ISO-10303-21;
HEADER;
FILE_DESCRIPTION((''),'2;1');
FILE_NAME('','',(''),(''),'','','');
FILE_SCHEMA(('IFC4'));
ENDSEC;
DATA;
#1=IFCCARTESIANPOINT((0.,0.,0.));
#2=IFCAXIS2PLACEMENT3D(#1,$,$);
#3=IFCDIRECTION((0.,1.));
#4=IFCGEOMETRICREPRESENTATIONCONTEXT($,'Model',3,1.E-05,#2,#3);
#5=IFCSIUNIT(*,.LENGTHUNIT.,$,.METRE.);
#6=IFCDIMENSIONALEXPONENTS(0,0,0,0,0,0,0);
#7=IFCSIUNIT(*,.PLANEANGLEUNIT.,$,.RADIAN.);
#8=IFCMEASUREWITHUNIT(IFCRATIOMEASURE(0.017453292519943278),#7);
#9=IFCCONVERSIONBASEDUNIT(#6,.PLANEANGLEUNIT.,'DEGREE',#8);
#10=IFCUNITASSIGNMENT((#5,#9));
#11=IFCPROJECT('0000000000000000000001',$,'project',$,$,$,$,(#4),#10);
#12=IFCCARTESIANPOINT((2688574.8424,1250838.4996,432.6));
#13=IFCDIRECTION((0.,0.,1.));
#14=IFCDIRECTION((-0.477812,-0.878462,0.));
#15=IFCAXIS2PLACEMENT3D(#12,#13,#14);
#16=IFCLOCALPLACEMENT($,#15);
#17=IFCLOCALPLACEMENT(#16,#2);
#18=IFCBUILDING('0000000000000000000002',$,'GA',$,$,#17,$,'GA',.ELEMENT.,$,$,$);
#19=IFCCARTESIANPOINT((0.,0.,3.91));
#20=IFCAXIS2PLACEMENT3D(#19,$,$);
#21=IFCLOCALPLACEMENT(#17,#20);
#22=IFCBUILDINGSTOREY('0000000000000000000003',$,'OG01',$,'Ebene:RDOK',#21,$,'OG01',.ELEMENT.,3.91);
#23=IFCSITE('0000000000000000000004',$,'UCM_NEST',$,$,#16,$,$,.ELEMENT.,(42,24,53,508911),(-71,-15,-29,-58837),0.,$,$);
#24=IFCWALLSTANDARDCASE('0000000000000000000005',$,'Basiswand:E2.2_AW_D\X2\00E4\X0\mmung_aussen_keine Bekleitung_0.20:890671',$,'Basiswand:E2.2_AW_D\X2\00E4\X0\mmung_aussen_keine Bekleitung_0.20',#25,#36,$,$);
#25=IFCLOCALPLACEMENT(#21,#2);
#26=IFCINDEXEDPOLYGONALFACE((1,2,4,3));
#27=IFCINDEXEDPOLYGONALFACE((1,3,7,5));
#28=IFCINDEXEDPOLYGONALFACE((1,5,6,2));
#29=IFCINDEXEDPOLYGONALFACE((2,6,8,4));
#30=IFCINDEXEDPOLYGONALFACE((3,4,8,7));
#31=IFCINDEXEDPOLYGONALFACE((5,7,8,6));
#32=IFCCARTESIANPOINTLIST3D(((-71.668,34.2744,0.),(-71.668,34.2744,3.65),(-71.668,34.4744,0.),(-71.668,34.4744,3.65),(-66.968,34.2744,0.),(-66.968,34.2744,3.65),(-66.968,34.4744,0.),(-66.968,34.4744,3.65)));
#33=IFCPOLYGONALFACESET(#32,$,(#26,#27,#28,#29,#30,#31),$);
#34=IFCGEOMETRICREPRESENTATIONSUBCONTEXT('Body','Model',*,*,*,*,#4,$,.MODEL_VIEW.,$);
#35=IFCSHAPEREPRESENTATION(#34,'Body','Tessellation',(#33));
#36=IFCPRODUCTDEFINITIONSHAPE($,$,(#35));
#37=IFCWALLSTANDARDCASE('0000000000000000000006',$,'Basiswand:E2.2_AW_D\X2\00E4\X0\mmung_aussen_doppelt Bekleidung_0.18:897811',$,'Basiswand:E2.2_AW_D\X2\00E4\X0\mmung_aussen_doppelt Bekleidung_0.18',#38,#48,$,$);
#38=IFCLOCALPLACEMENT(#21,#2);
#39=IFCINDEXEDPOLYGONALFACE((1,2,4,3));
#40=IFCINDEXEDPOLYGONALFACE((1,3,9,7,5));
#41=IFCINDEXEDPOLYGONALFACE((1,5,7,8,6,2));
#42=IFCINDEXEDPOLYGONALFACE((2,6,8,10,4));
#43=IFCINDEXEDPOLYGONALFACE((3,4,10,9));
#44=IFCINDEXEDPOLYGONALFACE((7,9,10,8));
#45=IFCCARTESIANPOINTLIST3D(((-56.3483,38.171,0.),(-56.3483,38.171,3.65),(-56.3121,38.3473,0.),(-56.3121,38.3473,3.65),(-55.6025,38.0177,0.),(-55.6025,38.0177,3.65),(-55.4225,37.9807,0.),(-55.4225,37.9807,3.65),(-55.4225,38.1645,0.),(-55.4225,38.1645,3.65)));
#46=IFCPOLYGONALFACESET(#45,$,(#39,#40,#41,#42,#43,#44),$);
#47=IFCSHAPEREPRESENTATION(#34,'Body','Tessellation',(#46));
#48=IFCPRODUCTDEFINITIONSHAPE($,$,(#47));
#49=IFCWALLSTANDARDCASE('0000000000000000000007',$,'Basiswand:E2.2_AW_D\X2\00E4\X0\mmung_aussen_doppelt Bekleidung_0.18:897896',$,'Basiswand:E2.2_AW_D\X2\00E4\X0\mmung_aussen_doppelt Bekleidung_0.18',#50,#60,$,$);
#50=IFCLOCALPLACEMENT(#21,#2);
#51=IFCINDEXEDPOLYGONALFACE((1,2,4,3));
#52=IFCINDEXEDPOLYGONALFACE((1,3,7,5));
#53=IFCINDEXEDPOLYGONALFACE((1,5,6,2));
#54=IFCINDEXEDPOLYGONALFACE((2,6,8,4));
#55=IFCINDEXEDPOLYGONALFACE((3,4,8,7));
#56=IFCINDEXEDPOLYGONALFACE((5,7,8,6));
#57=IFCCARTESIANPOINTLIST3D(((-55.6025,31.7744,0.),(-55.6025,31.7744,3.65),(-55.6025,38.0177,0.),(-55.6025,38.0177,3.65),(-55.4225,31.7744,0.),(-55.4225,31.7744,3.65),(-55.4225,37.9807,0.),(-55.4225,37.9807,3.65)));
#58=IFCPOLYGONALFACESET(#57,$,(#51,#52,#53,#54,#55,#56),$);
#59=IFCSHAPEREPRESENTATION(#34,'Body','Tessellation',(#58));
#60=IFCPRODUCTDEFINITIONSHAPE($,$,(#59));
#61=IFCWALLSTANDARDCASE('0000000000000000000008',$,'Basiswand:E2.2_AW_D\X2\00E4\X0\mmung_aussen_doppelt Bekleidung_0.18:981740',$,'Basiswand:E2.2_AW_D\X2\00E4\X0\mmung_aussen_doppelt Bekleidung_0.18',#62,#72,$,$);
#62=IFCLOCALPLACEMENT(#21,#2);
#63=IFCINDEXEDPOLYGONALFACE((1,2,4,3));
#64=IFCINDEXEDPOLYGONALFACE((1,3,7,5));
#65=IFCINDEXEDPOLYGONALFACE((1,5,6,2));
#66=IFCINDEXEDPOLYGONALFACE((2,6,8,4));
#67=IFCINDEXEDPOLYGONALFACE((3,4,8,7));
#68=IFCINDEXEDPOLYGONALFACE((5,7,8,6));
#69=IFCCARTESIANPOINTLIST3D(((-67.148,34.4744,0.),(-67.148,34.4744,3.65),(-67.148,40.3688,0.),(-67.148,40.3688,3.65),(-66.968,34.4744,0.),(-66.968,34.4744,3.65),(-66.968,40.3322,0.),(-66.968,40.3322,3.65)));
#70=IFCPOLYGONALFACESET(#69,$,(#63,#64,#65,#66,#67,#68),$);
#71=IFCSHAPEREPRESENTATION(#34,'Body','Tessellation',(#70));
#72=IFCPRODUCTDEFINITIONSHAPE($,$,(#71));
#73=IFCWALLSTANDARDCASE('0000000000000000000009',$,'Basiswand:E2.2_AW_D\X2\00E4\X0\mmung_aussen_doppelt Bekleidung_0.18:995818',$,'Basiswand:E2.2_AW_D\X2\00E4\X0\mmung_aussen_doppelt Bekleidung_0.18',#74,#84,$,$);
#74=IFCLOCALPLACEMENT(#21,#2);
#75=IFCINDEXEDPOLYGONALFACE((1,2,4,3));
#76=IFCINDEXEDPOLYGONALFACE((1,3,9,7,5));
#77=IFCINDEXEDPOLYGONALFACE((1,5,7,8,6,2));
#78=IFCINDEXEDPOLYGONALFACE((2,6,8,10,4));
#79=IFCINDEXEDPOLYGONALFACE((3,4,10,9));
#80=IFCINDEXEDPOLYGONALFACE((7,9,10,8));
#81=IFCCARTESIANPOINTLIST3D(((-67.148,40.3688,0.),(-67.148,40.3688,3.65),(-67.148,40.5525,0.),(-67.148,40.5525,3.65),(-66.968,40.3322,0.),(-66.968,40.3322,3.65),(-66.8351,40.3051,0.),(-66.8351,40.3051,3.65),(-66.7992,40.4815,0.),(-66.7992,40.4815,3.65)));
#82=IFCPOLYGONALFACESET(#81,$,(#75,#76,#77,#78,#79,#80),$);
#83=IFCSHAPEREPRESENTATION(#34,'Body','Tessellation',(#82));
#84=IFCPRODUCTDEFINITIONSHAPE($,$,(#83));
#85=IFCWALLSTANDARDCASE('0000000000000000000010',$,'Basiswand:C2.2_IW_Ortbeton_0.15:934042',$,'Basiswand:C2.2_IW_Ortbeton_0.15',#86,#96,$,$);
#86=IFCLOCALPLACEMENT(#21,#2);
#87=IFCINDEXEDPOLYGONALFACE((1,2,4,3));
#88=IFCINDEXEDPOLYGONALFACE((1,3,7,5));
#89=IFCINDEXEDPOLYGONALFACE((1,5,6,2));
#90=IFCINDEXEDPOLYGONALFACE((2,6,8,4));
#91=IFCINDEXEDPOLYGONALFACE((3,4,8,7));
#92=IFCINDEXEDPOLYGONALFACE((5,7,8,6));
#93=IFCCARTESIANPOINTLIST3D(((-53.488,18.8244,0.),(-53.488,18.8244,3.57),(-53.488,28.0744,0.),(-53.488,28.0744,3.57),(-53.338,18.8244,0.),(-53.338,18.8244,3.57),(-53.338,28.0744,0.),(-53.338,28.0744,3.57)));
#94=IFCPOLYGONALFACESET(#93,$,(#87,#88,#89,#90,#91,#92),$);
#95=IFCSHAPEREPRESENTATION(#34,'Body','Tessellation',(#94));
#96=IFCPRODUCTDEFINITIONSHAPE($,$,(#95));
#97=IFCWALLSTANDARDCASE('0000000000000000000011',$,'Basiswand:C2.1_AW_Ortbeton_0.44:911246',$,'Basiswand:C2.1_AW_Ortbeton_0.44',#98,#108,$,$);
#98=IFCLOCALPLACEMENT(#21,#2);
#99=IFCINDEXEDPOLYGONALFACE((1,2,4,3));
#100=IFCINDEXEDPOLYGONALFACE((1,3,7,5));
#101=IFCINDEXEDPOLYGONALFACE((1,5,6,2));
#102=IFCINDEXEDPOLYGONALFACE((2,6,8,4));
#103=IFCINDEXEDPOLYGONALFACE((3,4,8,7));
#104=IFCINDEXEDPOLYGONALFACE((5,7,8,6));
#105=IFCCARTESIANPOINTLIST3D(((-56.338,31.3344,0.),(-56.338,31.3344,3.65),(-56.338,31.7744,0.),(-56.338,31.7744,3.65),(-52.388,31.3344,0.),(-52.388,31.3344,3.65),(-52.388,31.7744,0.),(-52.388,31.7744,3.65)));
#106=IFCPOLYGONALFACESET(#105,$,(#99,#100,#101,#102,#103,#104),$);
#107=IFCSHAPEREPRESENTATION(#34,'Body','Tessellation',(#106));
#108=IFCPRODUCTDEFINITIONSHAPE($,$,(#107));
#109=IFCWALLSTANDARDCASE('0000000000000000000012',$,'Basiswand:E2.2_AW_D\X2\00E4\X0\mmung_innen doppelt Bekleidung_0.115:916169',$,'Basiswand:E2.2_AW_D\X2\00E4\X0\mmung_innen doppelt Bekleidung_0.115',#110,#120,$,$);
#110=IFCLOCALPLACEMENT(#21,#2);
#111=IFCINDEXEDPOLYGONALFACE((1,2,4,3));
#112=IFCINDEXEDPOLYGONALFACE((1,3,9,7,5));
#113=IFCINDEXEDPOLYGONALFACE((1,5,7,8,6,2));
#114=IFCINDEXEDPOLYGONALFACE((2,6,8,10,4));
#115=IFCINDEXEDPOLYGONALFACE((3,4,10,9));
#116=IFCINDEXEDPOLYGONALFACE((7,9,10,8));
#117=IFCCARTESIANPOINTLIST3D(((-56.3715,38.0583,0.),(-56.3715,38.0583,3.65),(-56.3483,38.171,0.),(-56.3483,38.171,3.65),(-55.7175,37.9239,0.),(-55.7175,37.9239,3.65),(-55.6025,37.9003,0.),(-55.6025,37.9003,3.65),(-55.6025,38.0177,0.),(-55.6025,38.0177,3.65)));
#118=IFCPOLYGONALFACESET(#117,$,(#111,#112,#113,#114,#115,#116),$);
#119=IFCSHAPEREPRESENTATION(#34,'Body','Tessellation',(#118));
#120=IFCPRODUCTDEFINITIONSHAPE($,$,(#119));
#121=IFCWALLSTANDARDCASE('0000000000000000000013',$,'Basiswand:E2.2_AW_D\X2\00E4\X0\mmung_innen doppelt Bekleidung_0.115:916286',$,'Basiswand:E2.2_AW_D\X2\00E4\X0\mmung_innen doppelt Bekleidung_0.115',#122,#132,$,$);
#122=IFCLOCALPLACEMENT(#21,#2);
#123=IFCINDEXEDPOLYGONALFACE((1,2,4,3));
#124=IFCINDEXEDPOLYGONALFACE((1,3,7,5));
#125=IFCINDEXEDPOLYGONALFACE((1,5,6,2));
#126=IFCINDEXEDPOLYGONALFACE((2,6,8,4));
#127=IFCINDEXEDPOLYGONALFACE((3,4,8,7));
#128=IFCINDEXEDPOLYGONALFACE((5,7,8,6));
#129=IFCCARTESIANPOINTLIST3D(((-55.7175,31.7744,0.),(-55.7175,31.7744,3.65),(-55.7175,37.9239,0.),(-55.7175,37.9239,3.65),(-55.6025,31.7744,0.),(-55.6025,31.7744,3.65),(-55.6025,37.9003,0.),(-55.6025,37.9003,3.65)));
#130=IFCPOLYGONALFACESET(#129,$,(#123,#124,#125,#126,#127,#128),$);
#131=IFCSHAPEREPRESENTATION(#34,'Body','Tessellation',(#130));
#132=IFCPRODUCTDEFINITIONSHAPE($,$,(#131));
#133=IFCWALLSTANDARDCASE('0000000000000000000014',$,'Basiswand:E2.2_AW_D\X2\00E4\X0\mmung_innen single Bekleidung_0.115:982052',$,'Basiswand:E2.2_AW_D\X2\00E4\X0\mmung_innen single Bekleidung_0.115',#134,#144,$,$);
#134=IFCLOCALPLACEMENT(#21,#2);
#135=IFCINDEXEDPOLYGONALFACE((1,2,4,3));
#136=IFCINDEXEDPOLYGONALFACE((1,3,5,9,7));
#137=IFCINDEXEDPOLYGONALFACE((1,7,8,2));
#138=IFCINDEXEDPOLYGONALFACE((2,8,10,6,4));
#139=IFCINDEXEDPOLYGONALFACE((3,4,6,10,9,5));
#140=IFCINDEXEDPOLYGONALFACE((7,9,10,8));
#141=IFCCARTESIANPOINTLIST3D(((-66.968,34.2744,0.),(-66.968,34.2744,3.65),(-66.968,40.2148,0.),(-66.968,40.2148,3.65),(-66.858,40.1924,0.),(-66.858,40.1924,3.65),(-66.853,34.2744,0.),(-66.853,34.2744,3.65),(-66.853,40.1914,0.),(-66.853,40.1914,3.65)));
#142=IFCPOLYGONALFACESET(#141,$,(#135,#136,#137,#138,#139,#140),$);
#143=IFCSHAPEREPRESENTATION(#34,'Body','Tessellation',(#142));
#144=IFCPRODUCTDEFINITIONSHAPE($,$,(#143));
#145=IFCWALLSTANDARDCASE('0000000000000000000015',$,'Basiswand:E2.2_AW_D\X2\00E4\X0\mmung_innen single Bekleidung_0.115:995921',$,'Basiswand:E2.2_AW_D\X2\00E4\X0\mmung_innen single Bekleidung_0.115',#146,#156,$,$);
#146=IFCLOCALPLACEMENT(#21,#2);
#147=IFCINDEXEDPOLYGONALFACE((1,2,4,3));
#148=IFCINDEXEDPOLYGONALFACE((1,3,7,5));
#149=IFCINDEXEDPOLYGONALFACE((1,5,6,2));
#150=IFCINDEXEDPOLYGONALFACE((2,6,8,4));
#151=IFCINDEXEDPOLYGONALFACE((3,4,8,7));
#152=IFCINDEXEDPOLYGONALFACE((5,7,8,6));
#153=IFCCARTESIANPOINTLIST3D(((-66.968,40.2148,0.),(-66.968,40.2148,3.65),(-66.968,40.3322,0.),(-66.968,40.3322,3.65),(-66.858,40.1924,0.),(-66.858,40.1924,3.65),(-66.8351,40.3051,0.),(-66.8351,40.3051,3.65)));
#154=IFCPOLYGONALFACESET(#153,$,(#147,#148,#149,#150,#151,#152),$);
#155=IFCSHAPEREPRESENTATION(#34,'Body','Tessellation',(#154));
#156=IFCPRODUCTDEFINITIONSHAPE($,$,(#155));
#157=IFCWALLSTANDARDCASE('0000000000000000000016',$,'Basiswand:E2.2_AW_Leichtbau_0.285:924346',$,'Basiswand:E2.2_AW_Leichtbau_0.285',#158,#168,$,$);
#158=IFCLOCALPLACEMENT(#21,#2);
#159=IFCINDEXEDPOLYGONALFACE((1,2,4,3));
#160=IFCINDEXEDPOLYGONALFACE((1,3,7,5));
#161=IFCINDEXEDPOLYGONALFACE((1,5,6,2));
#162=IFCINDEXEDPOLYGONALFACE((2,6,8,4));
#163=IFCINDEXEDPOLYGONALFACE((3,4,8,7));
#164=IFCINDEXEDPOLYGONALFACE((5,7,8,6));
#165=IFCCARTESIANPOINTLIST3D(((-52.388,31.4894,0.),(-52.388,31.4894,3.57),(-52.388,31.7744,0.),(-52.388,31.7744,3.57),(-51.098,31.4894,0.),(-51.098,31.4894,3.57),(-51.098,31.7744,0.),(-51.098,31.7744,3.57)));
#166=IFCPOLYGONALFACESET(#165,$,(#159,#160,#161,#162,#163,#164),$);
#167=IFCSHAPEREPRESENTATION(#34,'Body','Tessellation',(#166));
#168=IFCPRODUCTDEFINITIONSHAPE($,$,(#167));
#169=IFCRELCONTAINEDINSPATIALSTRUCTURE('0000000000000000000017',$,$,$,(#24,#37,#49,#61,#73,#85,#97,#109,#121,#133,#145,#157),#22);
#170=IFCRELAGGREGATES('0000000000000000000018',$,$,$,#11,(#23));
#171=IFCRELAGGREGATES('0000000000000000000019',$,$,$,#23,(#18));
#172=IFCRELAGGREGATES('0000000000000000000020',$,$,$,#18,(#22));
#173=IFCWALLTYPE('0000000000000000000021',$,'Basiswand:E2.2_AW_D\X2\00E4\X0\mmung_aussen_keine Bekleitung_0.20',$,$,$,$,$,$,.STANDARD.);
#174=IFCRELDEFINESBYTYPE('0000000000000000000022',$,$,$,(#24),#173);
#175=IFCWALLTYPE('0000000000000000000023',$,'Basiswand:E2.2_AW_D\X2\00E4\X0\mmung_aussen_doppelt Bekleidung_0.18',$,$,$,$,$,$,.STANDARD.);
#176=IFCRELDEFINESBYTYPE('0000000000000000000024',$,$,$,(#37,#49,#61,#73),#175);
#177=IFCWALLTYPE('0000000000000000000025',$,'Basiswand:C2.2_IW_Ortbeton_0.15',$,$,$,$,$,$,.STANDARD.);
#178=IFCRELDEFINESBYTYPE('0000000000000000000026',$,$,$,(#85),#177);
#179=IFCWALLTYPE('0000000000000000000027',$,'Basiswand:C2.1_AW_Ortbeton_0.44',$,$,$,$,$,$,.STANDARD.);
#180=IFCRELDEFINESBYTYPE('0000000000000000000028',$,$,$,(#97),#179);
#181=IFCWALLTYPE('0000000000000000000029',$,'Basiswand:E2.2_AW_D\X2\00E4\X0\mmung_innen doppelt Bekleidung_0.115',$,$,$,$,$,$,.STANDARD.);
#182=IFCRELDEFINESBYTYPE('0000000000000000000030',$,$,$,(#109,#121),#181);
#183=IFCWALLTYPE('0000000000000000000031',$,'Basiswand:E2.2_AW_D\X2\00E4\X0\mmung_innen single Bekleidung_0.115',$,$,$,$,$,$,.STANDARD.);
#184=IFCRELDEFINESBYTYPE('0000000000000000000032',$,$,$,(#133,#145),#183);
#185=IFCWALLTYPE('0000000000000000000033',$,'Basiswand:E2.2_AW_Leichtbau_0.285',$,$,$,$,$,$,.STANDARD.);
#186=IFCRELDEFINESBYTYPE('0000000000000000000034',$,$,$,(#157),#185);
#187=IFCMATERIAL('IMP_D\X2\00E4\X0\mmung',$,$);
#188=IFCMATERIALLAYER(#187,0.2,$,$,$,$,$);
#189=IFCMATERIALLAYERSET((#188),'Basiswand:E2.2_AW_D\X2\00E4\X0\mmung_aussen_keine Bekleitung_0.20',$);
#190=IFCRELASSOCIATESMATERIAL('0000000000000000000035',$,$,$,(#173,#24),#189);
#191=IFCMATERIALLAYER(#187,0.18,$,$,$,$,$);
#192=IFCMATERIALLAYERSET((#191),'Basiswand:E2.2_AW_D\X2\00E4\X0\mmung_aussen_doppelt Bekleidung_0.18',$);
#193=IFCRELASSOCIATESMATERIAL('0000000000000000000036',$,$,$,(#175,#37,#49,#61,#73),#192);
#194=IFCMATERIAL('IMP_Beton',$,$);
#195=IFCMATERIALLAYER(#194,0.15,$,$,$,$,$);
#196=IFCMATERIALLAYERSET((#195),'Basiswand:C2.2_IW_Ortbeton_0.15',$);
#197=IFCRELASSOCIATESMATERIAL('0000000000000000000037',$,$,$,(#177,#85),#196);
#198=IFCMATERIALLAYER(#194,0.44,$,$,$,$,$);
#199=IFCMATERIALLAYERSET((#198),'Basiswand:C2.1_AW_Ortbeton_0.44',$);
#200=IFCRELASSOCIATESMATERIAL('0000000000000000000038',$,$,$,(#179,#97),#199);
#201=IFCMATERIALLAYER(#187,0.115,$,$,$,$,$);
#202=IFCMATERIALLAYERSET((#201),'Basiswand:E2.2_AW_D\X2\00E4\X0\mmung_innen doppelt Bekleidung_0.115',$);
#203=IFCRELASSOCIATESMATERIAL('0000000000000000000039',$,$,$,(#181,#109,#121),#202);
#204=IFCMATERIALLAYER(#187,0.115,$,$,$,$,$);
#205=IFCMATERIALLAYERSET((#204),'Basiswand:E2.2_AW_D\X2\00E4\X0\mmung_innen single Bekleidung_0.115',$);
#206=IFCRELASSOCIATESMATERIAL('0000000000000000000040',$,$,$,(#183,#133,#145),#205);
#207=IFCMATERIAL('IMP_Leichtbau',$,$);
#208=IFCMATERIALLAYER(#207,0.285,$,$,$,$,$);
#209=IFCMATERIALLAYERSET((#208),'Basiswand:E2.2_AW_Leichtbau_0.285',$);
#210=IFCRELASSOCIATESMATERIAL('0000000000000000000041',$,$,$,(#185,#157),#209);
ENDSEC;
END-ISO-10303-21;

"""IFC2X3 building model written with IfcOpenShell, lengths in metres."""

from ifc_helpers import new_model, entity, si_unit, converted_unit, direction, frame, frame_2d, origin, place, context, subcontext, project, spatial, polyline, rectangle, outline, extrude, clip, bounded_halfspace, material, layer, layer_set, layer_usage, type_object, element, save


model = new_model("IFC2X3")

# Units and contexts
model_context = context("Model", 3, precision=1e-05, world=origin(), true_north=direction((0.0, 1.0)))
body_context = subcontext(model_context, "Body", "Model", "MODEL_VIEW")
ifc_project = project(units=[si_unit("LENGTHUNIT", "METRE"), converted_unit("PLANEANGLEUNIT", "DEGREE", entity("IfcRatioMeasure", 0.017453292519943278), si_unit("PLANEANGLEUNIT", "RADIAN"), dimensions=[0, 0, 0, 0, 0, 0, 0])], contexts=[model_context])

# Site, building, storey
site_placement = place(None, frame((2688574.8424, 1250838.4996, 432.6), z_axis=(0.0, 0.0, 1.0), x_axis=(-0.477812, -0.878462, 0.0)))
site = spatial("IfcSite", under=ifc_project, at=site_placement, Name="UCM_NEST", CompositionType="ELEMENT", RefLatitude=(42, 24, 53, 508911), RefLongitude=(-71, -15, -29, -58837), RefElevation=0.0)
building_placement = place(site_placement, origin())
building = spatial("IfcBuilding", under=site, at=building_placement, Name="GA", LongName="GA", CompositionType="ELEMENT")
storey_placement = place(building_placement, frame((0.0, 0.0, 3.91)))
storey = spatial("IfcBuildingStorey", under=building, at=storey_placement, Name="OG01", ObjectType="Ebene:RDOK", LongName="OG01", CompositionType="ELEMENT", Elevation=3.91)

# Walls
ifc_material_1 = material(Name="IMP_Dämmung")
ifc_layer_1 = layer(ifc_material_1, 0.2)
ifc_layer_set_1 = layer_set([ifc_layer_1], Name="Basiswand:E2.2_AW_Dämmung_aussen_keine Bekleitung_0.20")
ifc_layer_usage_1 = layer_usage(ifc_layer_set_1, "AXIS2", "NEGATIVE", 0.1)
wall_type_1 = type_object("IfcWallType", Name="Basiswand:E2.2_AW_Dämmung_aussen_keine Bekleitung_0.20", PredefinedType="STANDARD", material=ifc_layer_set_1)
wall_1_placement = place(storey_placement, frame((-66.968, 34.3744, 0.0), z_axis=(0.0, 0.0, 1.0), x_axis=(-1.0, 0.0, 0.0)))
element("IfcWallStandardCase", 1, at=wall_1_placement, inside=storey, type_object=wall_type_1, material=ifc_layer_usage_1, Name="Basiswand:E2.2_AW_Dämmung_aussen_keine Bekleitung_0.20:890671", ObjectType="Basiswand:E2.2_AW_Dämmung_aussen_keine Bekleitung_0.20", context=body_context, shape_type="SweptSolid", body=[
    extrude(rectangle(XDim=4.7, YDim=0.2, at=frame_2d((2.35, 0.0), x_axis=(-1.0, 0.0))), origin(), (0.0, 0.0, 1.0), 3.65),
])
ifc_layer_2 = layer(ifc_material_1, 0.18)
ifc_layer_set_2 = layer_set([ifc_layer_2], Name="Basiswand:E2.2_AW_Dämmung_aussen_doppelt Bekleidung_0.18")
ifc_layer_usage_2 = layer_usage(ifc_layer_set_2, "AXIS2", "NEGATIVE", 0.09)
wall_type_2 = type_object("IfcWallType", Name="Basiswand:E2.2_AW_Dämmung_aussen_doppelt Bekleidung_0.18", PredefinedType="STANDARD", material=ifc_layer_set_2)
wall_2_placement = place(storey_placement, frame((-56.3302, 38.2591, 0.0), z_axis=(0.0, 0.0, 1.0), x_axis=(0.979529, -0.201305, 0.0)))
element("IfcWallStandardCase", 2, at=wall_2_placement, inside=storey, type_object=wall_type_2, material=ifc_layer_usage_2, Name="Basiswand:E2.2_AW_Dämmung_aussen_doppelt Bekleidung_0.18:897811", ObjectType="Basiswand:E2.2_AW_Dämmung_aussen_doppelt Bekleidung_0.18", context=body_context, shape_type="SweptSolid", body=[
    extrude(outline(polyline([(0.9451, -0.09), (0.9081, 0.09), (0.0, 0.09), (0.0, -0.09), (0.7614, -0.09), (0.9451, -0.09)])), origin(), (0.0, 0.0, 1.0), 3.65),
])
wall_3_placement = place(storey_placement, frame((-55.5125, 38.0177, 0.0), z_axis=(0.0, 0.0, 1.0), x_axis=(0.0, -1.0, 0.0)))
element("IfcWallStandardCase", 3, at=wall_3_placement, inside=storey, type_object=wall_type_2, material=ifc_layer_usage_2, Name="Basiswand:E2.2_AW_Dämmung_aussen_doppelt Bekleidung_0.18:897896", ObjectType="Basiswand:E2.2_AW_Dämmung_aussen_doppelt Bekleidung_0.18", context=body_context, shape_type="SweptSolid", body=[
    extrude(outline(polyline([(6.2433, -0.09), (6.2433, 0.09), (0.037, 0.09), (0.0, -0.09), (6.2433, -0.09)])), origin(), (0.0, 0.0, 1.0), 3.65),
])
wall_4_placement = place(storey_placement, frame((-67.058, 34.4744, 0.0), z_axis=(0.0, 0.0, 1.0), x_axis=(0.0, 1.0, 0.0)))
element("IfcWallStandardCase", 4, at=wall_4_placement, inside=storey, type_object=wall_type_2, material=ifc_layer_usage_2, Name="Basiswand:E2.2_AW_Dämmung_aussen_doppelt Bekleidung_0.18:981740", ObjectType="Basiswand:E2.2_AW_Dämmung_aussen_doppelt Bekleidung_0.18", context=body_context, shape_type="SweptSolid", body=[
    extrude(outline(polyline([(5.8577, -0.09), (5.8943, 0.09), (0.0, 0.09), (0.0, -0.09), (5.8577, -0.09)])), origin(), (0.0, 0.0, 1.0), 3.65),
])
wall_5_placement = place(storey_placement, frame((-67.1659, 40.4643, 0.0), z_axis=(0.0, 0.0, 1.0), x_axis=(0.979914, -0.199421, 0.0)))
element("IfcWallStandardCase", 5, at=wall_5_placement, inside=storey, type_object=wall_type_2, material=ifc_layer_usage_2, Name="Basiswand:E2.2_AW_Dämmung_aussen_doppelt Bekleidung_0.18:995818", ObjectType="Basiswand:E2.2_AW_Dämmung_aussen_doppelt Bekleidung_0.18", context=body_context, shape_type="SweptSolid", body=[
    extrude(outline(polyline([(0.356, -0.09), (0.356, 0.09), (0.0, 0.09), (0.0366, -0.09), (0.2203, -0.09), (0.356, -0.09)])), origin(), (0.0, 0.0, 1.0), 3.65),
])
ifc_material_2 = material(Name="IMP_Beton")
ifc_layer_3 = layer(ifc_material_2, 0.15)
ifc_layer_set_3 = layer_set([ifc_layer_3], Name="Basiswand:C2.2_IW_Ortbeton_0.15")
ifc_layer_usage_3 = layer_usage(ifc_layer_set_3, "AXIS2", "NEGATIVE", 0.075)
wall_type_3 = type_object("IfcWallType", Name="Basiswand:C2.2_IW_Ortbeton_0.15", PredefinedType="STANDARD", material=ifc_layer_set_3)
wall_6_placement = place(storey_placement, frame((-53.413, 28.0744, 0.0), z_axis=(0.0, 0.0, 1.0), x_axis=(0.0, -1.0, 0.0)))
element("IfcWallStandardCase", 6, at=wall_6_placement, inside=storey, type_object=wall_type_3, material=ifc_layer_usage_3, Name="Basiswand:C2.2_IW_Ortbeton_0.15:934042", ObjectType="Basiswand:C2.2_IW_Ortbeton_0.15", context=body_context, shape_type="Clipping", body=[
    clip(extrude(rectangle(XDim=9.25, YDim=0.15, at=frame_2d((4.625, 0.0), x_axis=(-1.0, 0.0))), origin(), (0.0, 0.0, 1.0), 3.57), bounded_halfspace(frame((0.0, -0.075, 3.57), z_axis=(0.0, 0.0, -1.0), x_axis=(1.0, 0.0, 0.0)), True, frame((0.0, -0.075, 3.57), z_axis=(0.0, 0.0, -1.0), x_axis=(1.0, 0.0, 0.0)), polyline([(0.0, 0.0), (0.0, -0.15), (9.1, -0.15), (9.25, -0.15), (9.25, 0.0), (0.0, 0.0)]))),
])
ifc_layer_4 = layer(ifc_material_2, 0.44)
ifc_layer_set_4 = layer_set([ifc_layer_4], Name="Basiswand:C2.1_AW_Ortbeton_0.44")
ifc_layer_usage_4 = layer_usage(ifc_layer_set_4, "AXIS2", "NEGATIVE", 0.22)
wall_type_4 = type_object("IfcWallType", Name="Basiswand:C2.1_AW_Ortbeton_0.44", PredefinedType="STANDARD", material=ifc_layer_set_4)
wall_7_placement = place(storey_placement, frame((-56.338, 31.5544, 0.0)))
element("IfcWallStandardCase", 7, at=wall_7_placement, inside=storey, type_object=wall_type_4, material=ifc_layer_usage_4, Name="Basiswand:C2.1_AW_Ortbeton_0.44:911246", ObjectType="Basiswand:C2.1_AW_Ortbeton_0.44", context=body_context, shape_type="SweptSolid", body=[
    extrude(rectangle(XDim=3.95, YDim=0.44, at=frame_2d((1.975, 0.0), x_axis=(-1.0, 0.0))), origin(), (0.0, 0.0, 1.0), 3.65),
])

# Walls
ifc_layer_5 = layer(ifc_material_1, 0.115)
ifc_layer_set_5 = layer_set([ifc_layer_5], Name="Basiswand:E2.2_AW_Dämmung_innen doppelt Bekleidung_0.115")
ifc_layer_usage_5 = layer_usage(ifc_layer_set_5, "AXIS2", "NEGATIVE", 0.0575)
wall_type_5 = type_object("IfcWallType", Name="Basiswand:E2.2_AW_Dämmung_innen doppelt Bekleidung_0.115", PredefinedType="STANDARD", material=ifc_layer_set_5)
wall_8_placement = place(storey_placement, frame((-56.3599, 38.1146, 0.0), z_axis=(0.0, 0.0, 1.0), x_axis=(0.979529, -0.201305, 0.0)))
element("IfcWallStandardCase", 8, at=wall_8_placement, inside=storey, type_object=wall_type_5, material=ifc_layer_usage_5, Name="Basiswand:E2.2_AW_Dämmung_innen doppelt Bekleidung_0.115:916169", ObjectType="Basiswand:E2.2_AW_Dämmung_innen doppelt Bekleidung_0.115", context=body_context, shape_type="SweptSolid", body=[
    extrude(outline(polyline([(0.785, -0.0575), (0.7614, 0.0575), (0.0, 0.0575), (0.0, -0.0575), (0.6676, -0.0575), (0.785, -0.0575)])), origin(), (0.0, 0.0, 1.0), 3.65),
])
wall_9_placement = place(storey_placement, frame((-55.66, 37.9239, 0.0), z_axis=(0.0, 0.0, 1.0), x_axis=(0.0, -1.0, 0.0)))
element("IfcWallStandardCase", 9, at=wall_9_placement, inside=storey, type_object=wall_type_5, material=ifc_layer_usage_5, Name="Basiswand:E2.2_AW_Dämmung_innen doppelt Bekleidung_0.115:916286", ObjectType="Basiswand:E2.2_AW_Dämmung_innen doppelt Bekleidung_0.115", context=body_context, shape_type="SweptSolid", body=[
    extrude(outline(polyline([(6.1495, -0.0575), (6.1495, 0.0575), (0.0236, 0.0575), (0.0, -0.0575), (6.1495, -0.0575)])), origin(), (0.0, 0.0, 1.0), 3.65),
])
ifc_layer_6 = layer(ifc_material_1, 0.115)
ifc_layer_set_6 = layer_set([ifc_layer_6], Name="Basiswand:E2.2_AW_Dämmung_innen single Bekleidung_0.115")
ifc_layer_usage_6 = layer_usage(ifc_layer_set_6, "AXIS2", "NEGATIVE", 0.0575)
wall_type_6 = type_object("IfcWallType", Name="Basiswand:E2.2_AW_Dämmung_innen single Bekleidung_0.115", PredefinedType="STANDARD", material=ifc_layer_set_6)
wall_10_placement = place(storey_placement, frame((-66.9105, 34.2744, 0.0), z_axis=(0.0, 0.0, 1.0), x_axis=(0.0, 1.0, 0.0)))
element("IfcWallStandardCase", 10, at=wall_10_placement, inside=storey, type_object=wall_type_6, material=ifc_layer_usage_6, Name="Basiswand:E2.2_AW_Dämmung_innen single Bekleidung_0.115:982052", ObjectType="Basiswand:E2.2_AW_Dämmung_innen single Bekleidung_0.115", context=body_context, shape_type="SweptSolid", body=[
    extrude(outline(polyline([(5.917, -0.0575), (5.918, -0.0525), (5.9404, 0.0575), (0.0, 0.0575), (0.0, -0.0575), (5.917, -0.0575)])), origin(), (0.0, 0.0, 1.0), 3.65),
])
wall_11_placement = place(storey_placement, frame((-66.9795, 40.2758, 0.0), z_axis=(0.0, 0.0, 1.0), x_axis=(0.979914, -0.199421, 0.0)))
element("IfcWallStandardCase", 11, at=wall_11_placement, inside=storey, type_object=wall_type_6, material=ifc_layer_usage_6, Name="Basiswand:E2.2_AW_Dämmung_innen single Bekleidung_0.115:995921", ObjectType="Basiswand:E2.2_AW_Dämmung_innen single Bekleidung_0.115", context=body_context, shape_type="SweptSolid", body=[
    extrude(outline(polyline([(0.1357, -0.0575), (0.1357, 0.0575), (0.0, 0.0575), (0.0234, -0.0575), (0.1357, -0.0575)])), origin(), (0.0, 0.0, 1.0), 3.65),
])
ifc_material_3 = material(Name="IMP_Leichtbau")
ifc_layer_7 = layer(ifc_material_3, 0.285)
ifc_layer_set_7 = layer_set([ifc_layer_7], Name="Basiswand:E2.2_AW_Leichtbau_0.285")
ifc_layer_usage_7 = layer_usage(ifc_layer_set_7, "AXIS2", "NEGATIVE", 0.1425)
wall_type_7 = type_object("IfcWallType", Name="Basiswand:E2.2_AW_Leichtbau_0.285", PredefinedType="STANDARD", material=ifc_layer_set_7)
wall_12_placement = place(storey_placement, frame((-52.388, 31.6319, 0.0)))
element("IfcWallStandardCase", 12, at=wall_12_placement, inside=storey, type_object=wall_type_7, material=ifc_layer_usage_7, Name="Basiswand:E2.2_AW_Leichtbau_0.285:924346", ObjectType="Basiswand:E2.2_AW_Leichtbau_0.285", context=body_context, shape_type="Clipping", body=[
    clip(extrude(rectangle(XDim=1.29, YDim=0.285, at=frame_2d((0.645, 0.0), x_axis=(-1.0, 0.0))), origin(), (0.0, 0.0, 1.0), 3.57), bounded_halfspace(frame((0.0, -0.1425, 3.57), z_axis=(0.0, 0.0, -1.0), x_axis=(0.0, -1.0, 0.0)), True, frame((0.0, -0.1425, 3.57), z_axis=(0.0, 0.0, -1.0), x_axis=(0.0, -1.0, 0.0)), polyline([(0.0, 0.0), (-0.285, 0.0), (-0.285, -1.29), (0.0, -1.29), (0.0, -1.11), (0.0, 0.0)]))),
])

save(model, "model.ifc")
